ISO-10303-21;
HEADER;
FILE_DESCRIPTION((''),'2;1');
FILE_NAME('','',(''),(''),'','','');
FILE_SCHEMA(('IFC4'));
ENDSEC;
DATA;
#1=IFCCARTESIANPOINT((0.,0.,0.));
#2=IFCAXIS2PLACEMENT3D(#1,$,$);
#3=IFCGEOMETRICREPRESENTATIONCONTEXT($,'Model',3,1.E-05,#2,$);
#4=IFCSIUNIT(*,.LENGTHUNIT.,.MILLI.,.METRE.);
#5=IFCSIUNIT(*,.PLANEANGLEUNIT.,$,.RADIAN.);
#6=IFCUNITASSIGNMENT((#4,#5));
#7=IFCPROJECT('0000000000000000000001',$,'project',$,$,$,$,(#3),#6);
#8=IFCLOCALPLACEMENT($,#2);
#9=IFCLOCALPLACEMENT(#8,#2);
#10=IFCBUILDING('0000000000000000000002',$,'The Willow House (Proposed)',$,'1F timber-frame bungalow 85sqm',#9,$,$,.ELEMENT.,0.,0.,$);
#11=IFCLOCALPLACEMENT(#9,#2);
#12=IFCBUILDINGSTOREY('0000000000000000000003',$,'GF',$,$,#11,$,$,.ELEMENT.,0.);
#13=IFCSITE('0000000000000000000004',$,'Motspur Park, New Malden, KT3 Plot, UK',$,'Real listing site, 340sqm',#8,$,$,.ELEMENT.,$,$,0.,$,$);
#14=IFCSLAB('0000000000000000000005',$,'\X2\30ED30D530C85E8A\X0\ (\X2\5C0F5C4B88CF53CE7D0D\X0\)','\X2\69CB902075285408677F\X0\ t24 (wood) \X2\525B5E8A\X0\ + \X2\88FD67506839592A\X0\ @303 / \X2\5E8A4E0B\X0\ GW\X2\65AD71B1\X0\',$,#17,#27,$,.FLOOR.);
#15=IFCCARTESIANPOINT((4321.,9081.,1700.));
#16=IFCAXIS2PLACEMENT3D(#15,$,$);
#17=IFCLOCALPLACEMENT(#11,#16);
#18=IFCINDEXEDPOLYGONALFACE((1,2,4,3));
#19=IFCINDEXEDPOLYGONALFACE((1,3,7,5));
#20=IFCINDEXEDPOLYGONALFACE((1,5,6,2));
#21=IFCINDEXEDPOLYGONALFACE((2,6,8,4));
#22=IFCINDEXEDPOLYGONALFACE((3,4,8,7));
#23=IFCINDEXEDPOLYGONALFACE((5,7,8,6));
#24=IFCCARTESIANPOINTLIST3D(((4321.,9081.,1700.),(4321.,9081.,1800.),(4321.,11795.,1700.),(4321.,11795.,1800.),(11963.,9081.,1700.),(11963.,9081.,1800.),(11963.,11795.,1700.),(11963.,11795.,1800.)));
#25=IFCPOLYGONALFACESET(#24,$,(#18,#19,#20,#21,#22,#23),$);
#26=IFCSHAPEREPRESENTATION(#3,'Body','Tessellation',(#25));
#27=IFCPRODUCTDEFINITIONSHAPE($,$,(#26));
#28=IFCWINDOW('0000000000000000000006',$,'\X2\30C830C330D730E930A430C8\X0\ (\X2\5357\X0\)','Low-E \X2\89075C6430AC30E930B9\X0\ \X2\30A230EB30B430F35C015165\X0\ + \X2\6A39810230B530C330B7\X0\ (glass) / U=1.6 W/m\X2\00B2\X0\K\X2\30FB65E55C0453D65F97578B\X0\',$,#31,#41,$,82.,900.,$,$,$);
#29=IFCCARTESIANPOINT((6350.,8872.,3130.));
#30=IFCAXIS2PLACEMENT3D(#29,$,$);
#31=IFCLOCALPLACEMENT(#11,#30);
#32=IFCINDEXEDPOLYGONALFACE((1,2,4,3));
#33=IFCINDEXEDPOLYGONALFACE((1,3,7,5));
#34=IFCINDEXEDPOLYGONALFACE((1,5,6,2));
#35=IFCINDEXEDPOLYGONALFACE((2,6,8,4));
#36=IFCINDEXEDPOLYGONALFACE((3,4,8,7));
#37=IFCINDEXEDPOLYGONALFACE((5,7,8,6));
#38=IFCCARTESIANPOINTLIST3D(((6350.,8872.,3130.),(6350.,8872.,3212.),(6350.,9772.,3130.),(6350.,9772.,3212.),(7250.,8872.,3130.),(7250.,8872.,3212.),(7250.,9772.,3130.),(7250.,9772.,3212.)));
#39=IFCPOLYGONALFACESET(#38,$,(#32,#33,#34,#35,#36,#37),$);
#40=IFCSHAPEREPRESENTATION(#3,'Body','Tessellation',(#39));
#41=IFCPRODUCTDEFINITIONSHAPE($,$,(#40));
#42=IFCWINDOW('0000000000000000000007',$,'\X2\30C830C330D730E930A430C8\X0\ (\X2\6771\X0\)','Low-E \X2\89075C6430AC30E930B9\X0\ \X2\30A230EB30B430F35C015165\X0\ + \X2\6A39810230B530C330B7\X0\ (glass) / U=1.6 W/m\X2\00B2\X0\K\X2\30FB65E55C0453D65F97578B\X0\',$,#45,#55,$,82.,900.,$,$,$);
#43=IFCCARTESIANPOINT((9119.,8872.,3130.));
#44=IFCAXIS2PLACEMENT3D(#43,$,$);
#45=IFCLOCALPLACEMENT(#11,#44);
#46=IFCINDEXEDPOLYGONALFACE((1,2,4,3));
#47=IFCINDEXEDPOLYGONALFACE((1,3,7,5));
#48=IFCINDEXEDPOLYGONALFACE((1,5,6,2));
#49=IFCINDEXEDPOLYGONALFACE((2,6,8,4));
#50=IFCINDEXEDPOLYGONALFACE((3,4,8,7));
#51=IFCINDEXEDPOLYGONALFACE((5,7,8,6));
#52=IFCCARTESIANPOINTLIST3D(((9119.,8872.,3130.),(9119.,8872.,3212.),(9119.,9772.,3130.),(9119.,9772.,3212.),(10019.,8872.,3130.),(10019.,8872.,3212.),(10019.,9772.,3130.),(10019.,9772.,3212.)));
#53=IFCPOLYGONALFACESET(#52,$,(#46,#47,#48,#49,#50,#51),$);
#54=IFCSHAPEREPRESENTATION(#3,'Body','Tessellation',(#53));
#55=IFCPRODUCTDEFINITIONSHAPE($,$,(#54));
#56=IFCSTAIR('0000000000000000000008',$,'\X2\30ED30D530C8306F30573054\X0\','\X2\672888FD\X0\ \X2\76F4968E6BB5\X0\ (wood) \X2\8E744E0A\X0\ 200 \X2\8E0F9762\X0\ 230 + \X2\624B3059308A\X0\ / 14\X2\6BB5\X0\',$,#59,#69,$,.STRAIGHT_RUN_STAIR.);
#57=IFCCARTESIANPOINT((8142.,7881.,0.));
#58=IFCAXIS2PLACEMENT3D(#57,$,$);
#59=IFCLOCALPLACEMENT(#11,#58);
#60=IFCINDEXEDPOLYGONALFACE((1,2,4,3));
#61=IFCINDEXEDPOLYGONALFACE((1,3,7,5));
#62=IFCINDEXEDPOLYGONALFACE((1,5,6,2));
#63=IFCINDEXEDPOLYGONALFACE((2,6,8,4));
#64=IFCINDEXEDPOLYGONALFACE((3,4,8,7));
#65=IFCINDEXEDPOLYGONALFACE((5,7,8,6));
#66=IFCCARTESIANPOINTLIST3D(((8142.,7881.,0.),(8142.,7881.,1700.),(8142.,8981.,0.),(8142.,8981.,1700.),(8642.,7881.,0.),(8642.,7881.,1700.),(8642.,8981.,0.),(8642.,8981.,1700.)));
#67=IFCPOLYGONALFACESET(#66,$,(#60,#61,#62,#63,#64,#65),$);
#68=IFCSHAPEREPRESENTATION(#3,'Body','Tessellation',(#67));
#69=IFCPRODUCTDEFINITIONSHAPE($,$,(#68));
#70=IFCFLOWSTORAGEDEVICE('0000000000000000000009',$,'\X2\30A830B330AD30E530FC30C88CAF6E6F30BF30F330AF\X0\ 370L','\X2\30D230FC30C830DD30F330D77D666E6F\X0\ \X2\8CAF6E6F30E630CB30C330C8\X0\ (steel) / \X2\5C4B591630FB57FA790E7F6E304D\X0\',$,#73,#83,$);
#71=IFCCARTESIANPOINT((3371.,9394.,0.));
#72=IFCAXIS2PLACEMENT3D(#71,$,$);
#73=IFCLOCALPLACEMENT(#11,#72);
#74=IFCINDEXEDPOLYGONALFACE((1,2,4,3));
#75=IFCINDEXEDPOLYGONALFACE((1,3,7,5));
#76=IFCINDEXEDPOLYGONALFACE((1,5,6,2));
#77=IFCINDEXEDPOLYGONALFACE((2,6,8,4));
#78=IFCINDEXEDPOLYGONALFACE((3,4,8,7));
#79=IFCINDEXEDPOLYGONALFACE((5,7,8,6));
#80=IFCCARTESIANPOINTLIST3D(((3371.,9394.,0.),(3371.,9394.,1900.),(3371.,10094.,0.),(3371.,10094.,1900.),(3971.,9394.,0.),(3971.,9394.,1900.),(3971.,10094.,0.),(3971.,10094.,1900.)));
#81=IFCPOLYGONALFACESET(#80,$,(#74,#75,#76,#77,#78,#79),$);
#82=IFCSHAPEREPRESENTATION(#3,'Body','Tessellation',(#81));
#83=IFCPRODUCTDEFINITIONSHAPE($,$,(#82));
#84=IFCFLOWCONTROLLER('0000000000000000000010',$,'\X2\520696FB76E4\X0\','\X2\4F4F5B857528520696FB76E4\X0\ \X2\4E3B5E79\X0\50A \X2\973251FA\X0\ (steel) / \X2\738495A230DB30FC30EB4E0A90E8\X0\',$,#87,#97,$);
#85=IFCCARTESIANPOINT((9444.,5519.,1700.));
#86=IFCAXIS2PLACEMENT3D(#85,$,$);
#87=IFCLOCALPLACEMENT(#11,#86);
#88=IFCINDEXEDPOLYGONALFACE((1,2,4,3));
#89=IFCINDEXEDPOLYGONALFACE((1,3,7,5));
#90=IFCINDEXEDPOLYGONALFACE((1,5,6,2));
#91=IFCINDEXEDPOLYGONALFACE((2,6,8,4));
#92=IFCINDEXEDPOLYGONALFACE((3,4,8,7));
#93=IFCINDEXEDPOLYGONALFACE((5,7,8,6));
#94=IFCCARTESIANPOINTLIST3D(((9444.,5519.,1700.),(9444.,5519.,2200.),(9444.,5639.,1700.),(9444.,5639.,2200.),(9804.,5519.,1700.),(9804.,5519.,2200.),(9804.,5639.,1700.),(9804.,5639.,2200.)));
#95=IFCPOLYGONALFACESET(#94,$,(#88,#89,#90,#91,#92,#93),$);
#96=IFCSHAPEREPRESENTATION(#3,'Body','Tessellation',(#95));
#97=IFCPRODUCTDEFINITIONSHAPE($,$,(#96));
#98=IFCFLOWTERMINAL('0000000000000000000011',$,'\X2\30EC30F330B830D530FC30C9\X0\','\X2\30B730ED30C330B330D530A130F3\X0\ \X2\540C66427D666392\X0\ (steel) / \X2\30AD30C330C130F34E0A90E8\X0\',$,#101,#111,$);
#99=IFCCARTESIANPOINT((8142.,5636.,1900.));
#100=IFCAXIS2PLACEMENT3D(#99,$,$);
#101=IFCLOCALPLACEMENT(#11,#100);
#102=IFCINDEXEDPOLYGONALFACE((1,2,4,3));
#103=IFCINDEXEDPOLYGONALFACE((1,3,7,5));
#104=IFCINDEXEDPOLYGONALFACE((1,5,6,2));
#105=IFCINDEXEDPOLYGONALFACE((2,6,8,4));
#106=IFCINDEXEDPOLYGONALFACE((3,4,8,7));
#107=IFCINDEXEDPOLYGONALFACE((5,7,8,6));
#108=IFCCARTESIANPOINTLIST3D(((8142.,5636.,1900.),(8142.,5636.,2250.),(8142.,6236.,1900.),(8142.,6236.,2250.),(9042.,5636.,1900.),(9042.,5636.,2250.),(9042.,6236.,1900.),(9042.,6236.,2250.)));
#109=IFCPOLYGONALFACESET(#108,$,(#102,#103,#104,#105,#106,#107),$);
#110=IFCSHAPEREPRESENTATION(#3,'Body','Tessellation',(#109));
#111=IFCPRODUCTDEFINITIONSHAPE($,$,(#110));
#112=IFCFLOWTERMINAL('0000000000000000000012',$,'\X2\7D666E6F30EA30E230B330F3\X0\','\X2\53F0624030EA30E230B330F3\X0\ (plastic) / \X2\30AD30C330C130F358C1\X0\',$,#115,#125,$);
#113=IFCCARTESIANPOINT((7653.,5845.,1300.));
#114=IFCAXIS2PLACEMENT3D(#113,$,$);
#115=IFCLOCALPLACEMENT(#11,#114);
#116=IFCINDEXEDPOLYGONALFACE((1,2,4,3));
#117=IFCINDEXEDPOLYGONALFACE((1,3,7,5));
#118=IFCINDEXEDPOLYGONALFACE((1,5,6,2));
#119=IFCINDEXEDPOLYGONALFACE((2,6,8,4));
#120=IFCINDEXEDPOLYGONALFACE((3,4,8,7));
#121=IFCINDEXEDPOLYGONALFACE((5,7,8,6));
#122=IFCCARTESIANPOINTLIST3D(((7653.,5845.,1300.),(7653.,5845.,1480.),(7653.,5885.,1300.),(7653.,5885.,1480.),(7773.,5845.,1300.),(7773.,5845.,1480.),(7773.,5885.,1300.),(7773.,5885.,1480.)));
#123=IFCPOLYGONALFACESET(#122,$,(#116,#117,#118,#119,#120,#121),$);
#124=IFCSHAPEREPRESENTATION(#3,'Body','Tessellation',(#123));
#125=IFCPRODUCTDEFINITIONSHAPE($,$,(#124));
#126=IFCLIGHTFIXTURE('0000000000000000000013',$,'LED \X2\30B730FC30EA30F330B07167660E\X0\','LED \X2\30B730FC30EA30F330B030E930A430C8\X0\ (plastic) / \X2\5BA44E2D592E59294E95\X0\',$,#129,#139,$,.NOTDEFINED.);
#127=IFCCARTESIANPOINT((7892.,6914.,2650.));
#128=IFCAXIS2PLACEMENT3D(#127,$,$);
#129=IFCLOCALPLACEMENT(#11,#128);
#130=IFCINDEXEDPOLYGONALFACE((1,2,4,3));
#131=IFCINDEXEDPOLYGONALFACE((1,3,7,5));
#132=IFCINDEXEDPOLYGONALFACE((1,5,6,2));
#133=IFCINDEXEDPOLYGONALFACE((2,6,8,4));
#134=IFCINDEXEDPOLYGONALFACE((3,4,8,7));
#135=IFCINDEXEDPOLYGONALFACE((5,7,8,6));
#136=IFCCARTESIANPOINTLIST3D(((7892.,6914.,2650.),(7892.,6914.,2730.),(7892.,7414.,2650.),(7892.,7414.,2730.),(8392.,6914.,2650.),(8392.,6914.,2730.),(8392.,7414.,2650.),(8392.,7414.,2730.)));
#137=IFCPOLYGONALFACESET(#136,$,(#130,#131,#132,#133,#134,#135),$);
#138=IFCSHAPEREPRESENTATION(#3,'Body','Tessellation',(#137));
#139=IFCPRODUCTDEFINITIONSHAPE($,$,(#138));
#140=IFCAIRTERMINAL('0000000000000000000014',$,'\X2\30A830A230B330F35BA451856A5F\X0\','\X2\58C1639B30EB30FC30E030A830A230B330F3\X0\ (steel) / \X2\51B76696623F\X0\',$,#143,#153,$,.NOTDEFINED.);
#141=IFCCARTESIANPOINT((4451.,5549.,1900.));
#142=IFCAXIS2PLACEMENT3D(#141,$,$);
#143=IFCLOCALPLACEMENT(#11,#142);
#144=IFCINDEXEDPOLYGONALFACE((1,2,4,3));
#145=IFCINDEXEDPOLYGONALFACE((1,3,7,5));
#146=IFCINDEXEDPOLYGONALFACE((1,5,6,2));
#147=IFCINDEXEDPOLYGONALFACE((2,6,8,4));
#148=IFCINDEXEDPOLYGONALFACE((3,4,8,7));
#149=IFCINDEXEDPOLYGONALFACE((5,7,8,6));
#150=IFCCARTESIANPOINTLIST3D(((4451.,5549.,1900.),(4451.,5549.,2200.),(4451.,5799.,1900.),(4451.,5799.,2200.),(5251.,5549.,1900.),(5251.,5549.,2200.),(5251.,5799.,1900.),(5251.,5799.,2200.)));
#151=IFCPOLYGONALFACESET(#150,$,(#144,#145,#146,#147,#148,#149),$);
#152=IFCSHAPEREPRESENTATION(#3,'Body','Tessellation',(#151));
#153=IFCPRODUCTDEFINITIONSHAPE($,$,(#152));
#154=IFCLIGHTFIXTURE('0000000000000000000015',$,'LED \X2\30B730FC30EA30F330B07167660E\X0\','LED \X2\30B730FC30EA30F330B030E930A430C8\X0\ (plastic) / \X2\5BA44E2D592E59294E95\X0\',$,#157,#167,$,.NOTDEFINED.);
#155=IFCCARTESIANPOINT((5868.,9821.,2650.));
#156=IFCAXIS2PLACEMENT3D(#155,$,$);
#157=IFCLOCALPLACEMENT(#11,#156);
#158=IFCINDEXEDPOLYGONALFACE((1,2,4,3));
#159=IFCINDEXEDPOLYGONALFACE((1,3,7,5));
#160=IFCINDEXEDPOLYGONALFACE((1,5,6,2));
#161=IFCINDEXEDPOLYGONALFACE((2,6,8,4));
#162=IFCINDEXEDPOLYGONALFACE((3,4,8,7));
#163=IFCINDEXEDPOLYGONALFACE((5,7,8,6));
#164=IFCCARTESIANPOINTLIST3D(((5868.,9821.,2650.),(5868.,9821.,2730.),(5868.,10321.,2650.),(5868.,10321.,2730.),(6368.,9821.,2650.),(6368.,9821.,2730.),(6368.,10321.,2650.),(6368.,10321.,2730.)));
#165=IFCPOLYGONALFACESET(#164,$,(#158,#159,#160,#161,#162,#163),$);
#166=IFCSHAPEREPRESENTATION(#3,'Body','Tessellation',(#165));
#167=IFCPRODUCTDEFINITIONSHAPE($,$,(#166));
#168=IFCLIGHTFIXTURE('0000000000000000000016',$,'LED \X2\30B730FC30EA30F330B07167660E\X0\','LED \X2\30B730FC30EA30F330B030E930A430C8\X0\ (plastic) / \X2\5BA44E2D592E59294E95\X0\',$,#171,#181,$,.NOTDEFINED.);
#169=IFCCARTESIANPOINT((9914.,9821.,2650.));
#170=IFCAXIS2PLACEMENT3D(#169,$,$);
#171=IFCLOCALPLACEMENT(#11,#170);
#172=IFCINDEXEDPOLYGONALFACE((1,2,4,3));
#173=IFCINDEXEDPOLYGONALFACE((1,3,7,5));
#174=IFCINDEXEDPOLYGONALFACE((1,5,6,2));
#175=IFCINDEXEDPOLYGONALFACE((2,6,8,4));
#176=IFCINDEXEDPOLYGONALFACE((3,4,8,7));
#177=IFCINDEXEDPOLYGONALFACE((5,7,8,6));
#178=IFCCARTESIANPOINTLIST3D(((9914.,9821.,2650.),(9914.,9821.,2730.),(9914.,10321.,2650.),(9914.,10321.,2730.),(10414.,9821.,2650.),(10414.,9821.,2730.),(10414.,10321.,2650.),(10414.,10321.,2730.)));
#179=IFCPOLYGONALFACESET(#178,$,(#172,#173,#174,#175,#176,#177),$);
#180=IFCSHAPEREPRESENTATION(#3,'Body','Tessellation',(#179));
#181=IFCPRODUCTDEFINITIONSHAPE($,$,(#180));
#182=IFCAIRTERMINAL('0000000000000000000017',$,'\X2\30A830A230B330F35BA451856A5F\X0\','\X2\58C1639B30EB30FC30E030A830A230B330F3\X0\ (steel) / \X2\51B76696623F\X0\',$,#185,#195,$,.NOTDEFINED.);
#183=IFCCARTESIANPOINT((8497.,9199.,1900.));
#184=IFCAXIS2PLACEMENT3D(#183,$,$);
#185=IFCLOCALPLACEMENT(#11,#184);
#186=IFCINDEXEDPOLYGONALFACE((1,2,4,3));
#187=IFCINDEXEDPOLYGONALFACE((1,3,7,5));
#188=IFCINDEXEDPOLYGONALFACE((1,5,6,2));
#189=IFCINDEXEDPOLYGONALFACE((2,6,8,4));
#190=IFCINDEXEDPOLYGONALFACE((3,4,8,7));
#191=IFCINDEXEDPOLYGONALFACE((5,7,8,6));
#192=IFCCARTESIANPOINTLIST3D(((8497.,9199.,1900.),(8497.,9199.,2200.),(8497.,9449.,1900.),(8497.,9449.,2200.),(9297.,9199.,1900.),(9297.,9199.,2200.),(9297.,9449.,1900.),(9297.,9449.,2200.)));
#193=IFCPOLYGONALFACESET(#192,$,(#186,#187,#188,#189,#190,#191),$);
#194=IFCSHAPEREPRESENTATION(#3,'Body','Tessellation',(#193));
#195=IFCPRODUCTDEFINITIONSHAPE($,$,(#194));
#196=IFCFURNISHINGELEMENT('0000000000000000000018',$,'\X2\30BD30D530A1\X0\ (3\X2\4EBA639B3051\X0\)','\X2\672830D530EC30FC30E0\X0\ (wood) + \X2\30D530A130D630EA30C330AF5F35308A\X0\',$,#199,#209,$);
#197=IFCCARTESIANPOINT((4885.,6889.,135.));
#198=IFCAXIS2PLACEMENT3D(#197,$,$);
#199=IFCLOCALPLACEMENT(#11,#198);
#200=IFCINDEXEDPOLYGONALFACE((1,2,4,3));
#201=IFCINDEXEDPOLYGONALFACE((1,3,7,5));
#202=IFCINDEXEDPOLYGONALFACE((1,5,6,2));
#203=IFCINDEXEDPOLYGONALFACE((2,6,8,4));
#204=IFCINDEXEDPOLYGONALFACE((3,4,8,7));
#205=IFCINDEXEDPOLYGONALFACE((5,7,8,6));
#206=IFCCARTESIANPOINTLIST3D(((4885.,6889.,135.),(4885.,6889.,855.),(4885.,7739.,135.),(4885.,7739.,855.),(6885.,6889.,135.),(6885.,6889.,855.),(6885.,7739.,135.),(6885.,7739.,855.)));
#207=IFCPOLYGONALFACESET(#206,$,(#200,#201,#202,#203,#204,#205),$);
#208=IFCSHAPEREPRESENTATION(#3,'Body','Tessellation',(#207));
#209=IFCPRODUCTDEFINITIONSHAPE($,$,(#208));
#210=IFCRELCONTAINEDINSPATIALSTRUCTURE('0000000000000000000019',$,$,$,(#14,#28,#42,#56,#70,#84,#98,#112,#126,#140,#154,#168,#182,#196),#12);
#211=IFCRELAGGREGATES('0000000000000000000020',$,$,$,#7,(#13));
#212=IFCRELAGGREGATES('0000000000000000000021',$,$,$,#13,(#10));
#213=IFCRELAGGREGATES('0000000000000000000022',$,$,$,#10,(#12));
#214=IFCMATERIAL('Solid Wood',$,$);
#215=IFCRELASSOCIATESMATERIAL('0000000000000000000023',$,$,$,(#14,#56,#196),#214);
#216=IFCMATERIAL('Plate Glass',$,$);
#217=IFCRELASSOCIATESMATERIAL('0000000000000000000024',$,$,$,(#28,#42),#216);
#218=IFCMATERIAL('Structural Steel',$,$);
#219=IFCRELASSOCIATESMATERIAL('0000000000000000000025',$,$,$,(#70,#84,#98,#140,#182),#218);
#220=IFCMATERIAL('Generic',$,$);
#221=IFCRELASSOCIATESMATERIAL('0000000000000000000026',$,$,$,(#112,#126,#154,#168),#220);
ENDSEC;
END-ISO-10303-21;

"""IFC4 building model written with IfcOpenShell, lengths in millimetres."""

from ifc_helpers import new_model, si_unit, frame, frame_2d, origin, place, context, project, spatial, rectangle, extrude, material, element, save


model = new_model("IFC4")

# Units and contexts
model_context = context("Model", 3, precision=1e-05, world=origin())
ifc_project = project(units=[si_unit("LENGTHUNIT", "METRE", prefix="MILLI"), si_unit("PLANEANGLEUNIT", "RADIAN")], contexts=[model_context])

# Site, building, storey
site_placement = place(None, origin())
site = spatial("IfcSite", under=ifc_project, at=site_placement, Name="Motspur Park, New Malden, KT3 Plot, UK", ObjectType="Real listing site, 340sqm", CompositionType="ELEMENT", RefElevation=0.0)
building_placement = place(site_placement, origin())
building = spatial("IfcBuilding", under=site, at=building_placement, Name="The Willow House (Proposed)", ObjectType="1F timber-frame bungalow 85sqm", CompositionType="ELEMENT", ElevationOfRefHeight=0.0, ElevationOfTerrain=0.0)
storey_placement = place(building_placement, origin())
storey = spatial("IfcBuildingStorey", under=building, at=storey_placement, Name="GF", CompositionType="ELEMENT", Elevation=0.0)

# Shared definitions
ifc_material_1 = material(Name="Solid Wood")

# Slab
slab_placement = place(storey_placement, frame((4321.0, 9081.0, 1700.0)))
element("IfcSlab", 1, at=slab_placement, inside=storey, material=ifc_material_1, Name="ロフト床 (小屋裏収納)", Description="構造用合板 t24 (wood) 剛床 + 製材根太 @303 / 床下 GW断熱", PredefinedType="FLOOR", context=model_context, shape_type="SweptSolid", body=[
    extrude(rectangle(XDim=7642.0, YDim=2714.0, at=frame_2d((3821.0, 1357.0))), frame((4321.0, 9081.0, 1700.0)), (0.0, 0.0, 1.0), 100.0),
])

# Windows
ifc_material_2 = material(Name="Plate Glass")
window_1_placement = place(storey_placement, frame((6350.0, 8872.0, 3130.0)))
element("IfcWindow", 2, at=window_1_placement, inside=storey, material=ifc_material_2, Name="トップライト (南)", Description="Low-E 複層ガラス アルゴン封入 + 樹脂サッシ (glass) / U=1.6 W/m²K・日射取得型", OverallHeight=82.0, OverallWidth=900.0, context=model_context, shape_type="SweptSolid", body=[
    extrude(rectangle(XDim=900.0, YDim=900.0, at=frame_2d((450.0, 450.0))), frame((6350.0, 8872.0, 3130.0)), (0.0, 0.0, 1.0), 82.0),
])
window_2_placement = place(storey_placement, frame((9119.0, 8872.0, 3130.0)))
element("IfcWindow", 3, at=window_2_placement, inside=storey, material=ifc_material_2, Name="トップライト (東)", Description="Low-E 複層ガラス アルゴン封入 + 樹脂サッシ (glass) / U=1.6 W/m²K・日射取得型", OverallHeight=82.0, OverallWidth=900.0, context=model_context, shape_type="SweptSolid", body=[
    extrude(rectangle(XDim=900.0, YDim=900.0, at=frame_2d((450.0, 450.0))), frame((9119.0, 8872.0, 3130.0)), (0.0, 0.0, 1.0), 82.0),
])

# Stair
stair_placement = place(storey_placement, frame((8142.0, 7881.0, 0.0)))
element("IfcStair", 4, at=stair_placement, inside=storey, material=ifc_material_1, Name="ロフトはしご", Description="木製 直階段 (wood) 蹴上 200 踏面 230 + 手すり / 14段", PredefinedType="STRAIGHT_RUN_STAIR", context=model_context, shape_type="SweptSolid", body=[
    extrude(rectangle(XDim=500.0, YDim=1100.0, at=frame_2d((250.0, 550.0))), frame((8142.0, 7881.0, 0.0)), (0.0, 0.0, 1.0), 1700.0),
])

# Flow storage device
ifc_material_3 = material(Name="Structural Steel")
flow_storage_device_placement = place(storey_placement, frame((3371.0, 9394.0, 0.0)))
element("IfcFlowStorageDevice", 5, at=flow_storage_device_placement, inside=storey, material=ifc_material_3, Name="エコキュート貯湯タンク 370L", Description="ヒートポンプ給湯 貯湯ユニット (steel) / 屋外・基礎置き", context=model_context, shape_type="SweptSolid", body=[
    extrude(rectangle(XDim=600.0, YDim=700.0, at=frame_2d((300.0, 350.0))), frame((3371.0, 9394.0, 0.0)), (0.0, 0.0, 1.0), 1900.0),
])

# Flow controller
flow_controller_placement = place(storey_placement, frame((9444.0, 5519.0, 1700.0)))
element("IfcFlowController", 6, at=flow_controller_placement, inside=storey, material=ifc_material_3, Name="分電盤", Description="住宅用分電盤 主幹50A 露出 (steel) / 玄関ホール上部", context=model_context, shape_type="SweptSolid", body=[
    extrude(rectangle(XDim=360.0, YDim=120.0, at=frame_2d((180.0, 60.0))), frame((9444.0, 5519.0, 1700.0)), (0.0, 0.0, 1.0), 500.0),
])

# Flow terminals
flow_terminal_1_placement = place(storey_placement, frame((8142.0, 5636.0, 1900.0)))
element("IfcFlowTerminal", 7, at=flow_terminal_1_placement, inside=storey, material=ifc_material_3, Name="レンジフード", Description="シロッコファン 同時給排 (steel) / キッチン上部", context=model_context, shape_type="SweptSolid", body=[
    extrude(rectangle(XDim=900.0, YDim=600.0, at=frame_2d((450.0, 300.0))), frame((8142.0, 5636.0, 1900.0)), (0.0, 0.0, 1.0), 350.0),
])
ifc_material_4 = material(Name="Generic")
flow_terminal_2_placement = place(storey_placement, frame((7653.0, 5845.0, 1300.0)))
element("IfcFlowTerminal", 8, at=flow_terminal_2_placement, inside=storey, material=ifc_material_4, Name="給湯リモコン", Description="台所リモコン (plastic) / キッチン壁", context=model_context, shape_type="SweptSolid", body=[
    extrude(rectangle(XDim=120.0, YDim=40.0, at=frame_2d((60.0, 20.0))), frame((7653.0, 5845.0, 1300.0)), (0.0, 0.0, 1.0), 180.0),
])

# Light fixture
light_fixture_1_placement = place(storey_placement, frame((7892.0, 6914.0, 2650.0)))
element("IfcLightFixture", 9, at=light_fixture_1_placement, inside=storey, material=ifc_material_4, Name="LED シーリング照明", Description="LED シーリングライト (plastic) / 室中央天井", PredefinedType="NOTDEFINED", context=model_context, shape_type="SweptSolid", body=[
    extrude(rectangle(XDim=500.0, YDim=500.0, at=frame_2d((250.0, 250.0))), frame((7892.0, 6914.0, 2650.0)), (0.0, 0.0, 1.0), 80.0),
])

# Air terminal
air_terminal_1_placement = place(storey_placement, frame((4451.0, 5549.0, 1900.0)))
element("IfcAirTerminal", 10, at=air_terminal_1_placement, inside=storey, material=ifc_material_3, Name="エアコン室内機", Description="壁掛ルームエアコン (steel) / 冷暖房", PredefinedType="NOTDEFINED", context=model_context, shape_type="SweptSolid", body=[
    extrude(rectangle(XDim=800.0, YDim=250.0, at=frame_2d((400.0, 125.0))), frame((4451.0, 5549.0, 1900.0)), (0.0, 0.0, 1.0), 300.0),
])

# Light fixtures
light_fixture_2_placement = place(storey_placement, frame((5868.0, 9821.0, 2650.0)))
element("IfcLightFixture", 11, at=light_fixture_2_placement, inside=storey, material=ifc_material_4, Name="LED シーリング照明", Description="LED シーリングライト (plastic) / 室中央天井", PredefinedType="NOTDEFINED", context=model_context, shape_type="SweptSolid", body=[
    extrude(rectangle(XDim=500.0, YDim=500.0, at=frame_2d((250.0, 250.0))), frame((5868.0, 9821.0, 2650.0)), (0.0, 0.0, 1.0), 80.0),
])
light_fixture_3_placement = place(storey_placement, frame((9914.0, 9821.0, 2650.0)))
element("IfcLightFixture", 12, at=light_fixture_3_placement, inside=storey, material=ifc_material_4, Name="LED シーリング照明", Description="LED シーリングライト (plastic) / 室中央天井", PredefinedType="NOTDEFINED", context=model_context, shape_type="SweptSolid", body=[
    extrude(rectangle(XDim=500.0, YDim=500.0, at=frame_2d((250.0, 250.0))), frame((9914.0, 9821.0, 2650.0)), (0.0, 0.0, 1.0), 80.0),
])

# Air terminal
air_terminal_2_placement = place(storey_placement, frame((8497.0, 9199.0, 1900.0)))
element("IfcAirTerminal", 13, at=air_terminal_2_placement, inside=storey, material=ifc_material_3, Name="エアコン室内機", Description="壁掛ルームエアコン (steel) / 冷暖房", PredefinedType="NOTDEFINED", context=model_context, shape_type="SweptSolid", body=[
    extrude(rectangle(XDim=800.0, YDim=250.0, at=frame_2d((400.0, 125.0))), frame((8497.0, 9199.0, 1900.0)), (0.0, 0.0, 1.0), 300.0),
])

# Furnishing element
furnishing_1_placement = place(storey_placement, frame((4885.0, 6889.0, 135.0)))
element("IfcFurnishingElement", 14, at=furnishing_1_placement, inside=storey, material=ifc_material_1, Name="ソファ (3人掛け)", Description="木フレーム (wood) + ファブリック張り", context=model_context, shape_type="SweptSolid", body=[
    extrude(rectangle(XDim=2000.0, YDim=850.0, at=frame_2d((1000.0, 425.0))), frame((4885.0, 6889.0, 135.0)), (0.0, 0.0, 1.0), 720.0),
])

save(model, "model.ifc")
